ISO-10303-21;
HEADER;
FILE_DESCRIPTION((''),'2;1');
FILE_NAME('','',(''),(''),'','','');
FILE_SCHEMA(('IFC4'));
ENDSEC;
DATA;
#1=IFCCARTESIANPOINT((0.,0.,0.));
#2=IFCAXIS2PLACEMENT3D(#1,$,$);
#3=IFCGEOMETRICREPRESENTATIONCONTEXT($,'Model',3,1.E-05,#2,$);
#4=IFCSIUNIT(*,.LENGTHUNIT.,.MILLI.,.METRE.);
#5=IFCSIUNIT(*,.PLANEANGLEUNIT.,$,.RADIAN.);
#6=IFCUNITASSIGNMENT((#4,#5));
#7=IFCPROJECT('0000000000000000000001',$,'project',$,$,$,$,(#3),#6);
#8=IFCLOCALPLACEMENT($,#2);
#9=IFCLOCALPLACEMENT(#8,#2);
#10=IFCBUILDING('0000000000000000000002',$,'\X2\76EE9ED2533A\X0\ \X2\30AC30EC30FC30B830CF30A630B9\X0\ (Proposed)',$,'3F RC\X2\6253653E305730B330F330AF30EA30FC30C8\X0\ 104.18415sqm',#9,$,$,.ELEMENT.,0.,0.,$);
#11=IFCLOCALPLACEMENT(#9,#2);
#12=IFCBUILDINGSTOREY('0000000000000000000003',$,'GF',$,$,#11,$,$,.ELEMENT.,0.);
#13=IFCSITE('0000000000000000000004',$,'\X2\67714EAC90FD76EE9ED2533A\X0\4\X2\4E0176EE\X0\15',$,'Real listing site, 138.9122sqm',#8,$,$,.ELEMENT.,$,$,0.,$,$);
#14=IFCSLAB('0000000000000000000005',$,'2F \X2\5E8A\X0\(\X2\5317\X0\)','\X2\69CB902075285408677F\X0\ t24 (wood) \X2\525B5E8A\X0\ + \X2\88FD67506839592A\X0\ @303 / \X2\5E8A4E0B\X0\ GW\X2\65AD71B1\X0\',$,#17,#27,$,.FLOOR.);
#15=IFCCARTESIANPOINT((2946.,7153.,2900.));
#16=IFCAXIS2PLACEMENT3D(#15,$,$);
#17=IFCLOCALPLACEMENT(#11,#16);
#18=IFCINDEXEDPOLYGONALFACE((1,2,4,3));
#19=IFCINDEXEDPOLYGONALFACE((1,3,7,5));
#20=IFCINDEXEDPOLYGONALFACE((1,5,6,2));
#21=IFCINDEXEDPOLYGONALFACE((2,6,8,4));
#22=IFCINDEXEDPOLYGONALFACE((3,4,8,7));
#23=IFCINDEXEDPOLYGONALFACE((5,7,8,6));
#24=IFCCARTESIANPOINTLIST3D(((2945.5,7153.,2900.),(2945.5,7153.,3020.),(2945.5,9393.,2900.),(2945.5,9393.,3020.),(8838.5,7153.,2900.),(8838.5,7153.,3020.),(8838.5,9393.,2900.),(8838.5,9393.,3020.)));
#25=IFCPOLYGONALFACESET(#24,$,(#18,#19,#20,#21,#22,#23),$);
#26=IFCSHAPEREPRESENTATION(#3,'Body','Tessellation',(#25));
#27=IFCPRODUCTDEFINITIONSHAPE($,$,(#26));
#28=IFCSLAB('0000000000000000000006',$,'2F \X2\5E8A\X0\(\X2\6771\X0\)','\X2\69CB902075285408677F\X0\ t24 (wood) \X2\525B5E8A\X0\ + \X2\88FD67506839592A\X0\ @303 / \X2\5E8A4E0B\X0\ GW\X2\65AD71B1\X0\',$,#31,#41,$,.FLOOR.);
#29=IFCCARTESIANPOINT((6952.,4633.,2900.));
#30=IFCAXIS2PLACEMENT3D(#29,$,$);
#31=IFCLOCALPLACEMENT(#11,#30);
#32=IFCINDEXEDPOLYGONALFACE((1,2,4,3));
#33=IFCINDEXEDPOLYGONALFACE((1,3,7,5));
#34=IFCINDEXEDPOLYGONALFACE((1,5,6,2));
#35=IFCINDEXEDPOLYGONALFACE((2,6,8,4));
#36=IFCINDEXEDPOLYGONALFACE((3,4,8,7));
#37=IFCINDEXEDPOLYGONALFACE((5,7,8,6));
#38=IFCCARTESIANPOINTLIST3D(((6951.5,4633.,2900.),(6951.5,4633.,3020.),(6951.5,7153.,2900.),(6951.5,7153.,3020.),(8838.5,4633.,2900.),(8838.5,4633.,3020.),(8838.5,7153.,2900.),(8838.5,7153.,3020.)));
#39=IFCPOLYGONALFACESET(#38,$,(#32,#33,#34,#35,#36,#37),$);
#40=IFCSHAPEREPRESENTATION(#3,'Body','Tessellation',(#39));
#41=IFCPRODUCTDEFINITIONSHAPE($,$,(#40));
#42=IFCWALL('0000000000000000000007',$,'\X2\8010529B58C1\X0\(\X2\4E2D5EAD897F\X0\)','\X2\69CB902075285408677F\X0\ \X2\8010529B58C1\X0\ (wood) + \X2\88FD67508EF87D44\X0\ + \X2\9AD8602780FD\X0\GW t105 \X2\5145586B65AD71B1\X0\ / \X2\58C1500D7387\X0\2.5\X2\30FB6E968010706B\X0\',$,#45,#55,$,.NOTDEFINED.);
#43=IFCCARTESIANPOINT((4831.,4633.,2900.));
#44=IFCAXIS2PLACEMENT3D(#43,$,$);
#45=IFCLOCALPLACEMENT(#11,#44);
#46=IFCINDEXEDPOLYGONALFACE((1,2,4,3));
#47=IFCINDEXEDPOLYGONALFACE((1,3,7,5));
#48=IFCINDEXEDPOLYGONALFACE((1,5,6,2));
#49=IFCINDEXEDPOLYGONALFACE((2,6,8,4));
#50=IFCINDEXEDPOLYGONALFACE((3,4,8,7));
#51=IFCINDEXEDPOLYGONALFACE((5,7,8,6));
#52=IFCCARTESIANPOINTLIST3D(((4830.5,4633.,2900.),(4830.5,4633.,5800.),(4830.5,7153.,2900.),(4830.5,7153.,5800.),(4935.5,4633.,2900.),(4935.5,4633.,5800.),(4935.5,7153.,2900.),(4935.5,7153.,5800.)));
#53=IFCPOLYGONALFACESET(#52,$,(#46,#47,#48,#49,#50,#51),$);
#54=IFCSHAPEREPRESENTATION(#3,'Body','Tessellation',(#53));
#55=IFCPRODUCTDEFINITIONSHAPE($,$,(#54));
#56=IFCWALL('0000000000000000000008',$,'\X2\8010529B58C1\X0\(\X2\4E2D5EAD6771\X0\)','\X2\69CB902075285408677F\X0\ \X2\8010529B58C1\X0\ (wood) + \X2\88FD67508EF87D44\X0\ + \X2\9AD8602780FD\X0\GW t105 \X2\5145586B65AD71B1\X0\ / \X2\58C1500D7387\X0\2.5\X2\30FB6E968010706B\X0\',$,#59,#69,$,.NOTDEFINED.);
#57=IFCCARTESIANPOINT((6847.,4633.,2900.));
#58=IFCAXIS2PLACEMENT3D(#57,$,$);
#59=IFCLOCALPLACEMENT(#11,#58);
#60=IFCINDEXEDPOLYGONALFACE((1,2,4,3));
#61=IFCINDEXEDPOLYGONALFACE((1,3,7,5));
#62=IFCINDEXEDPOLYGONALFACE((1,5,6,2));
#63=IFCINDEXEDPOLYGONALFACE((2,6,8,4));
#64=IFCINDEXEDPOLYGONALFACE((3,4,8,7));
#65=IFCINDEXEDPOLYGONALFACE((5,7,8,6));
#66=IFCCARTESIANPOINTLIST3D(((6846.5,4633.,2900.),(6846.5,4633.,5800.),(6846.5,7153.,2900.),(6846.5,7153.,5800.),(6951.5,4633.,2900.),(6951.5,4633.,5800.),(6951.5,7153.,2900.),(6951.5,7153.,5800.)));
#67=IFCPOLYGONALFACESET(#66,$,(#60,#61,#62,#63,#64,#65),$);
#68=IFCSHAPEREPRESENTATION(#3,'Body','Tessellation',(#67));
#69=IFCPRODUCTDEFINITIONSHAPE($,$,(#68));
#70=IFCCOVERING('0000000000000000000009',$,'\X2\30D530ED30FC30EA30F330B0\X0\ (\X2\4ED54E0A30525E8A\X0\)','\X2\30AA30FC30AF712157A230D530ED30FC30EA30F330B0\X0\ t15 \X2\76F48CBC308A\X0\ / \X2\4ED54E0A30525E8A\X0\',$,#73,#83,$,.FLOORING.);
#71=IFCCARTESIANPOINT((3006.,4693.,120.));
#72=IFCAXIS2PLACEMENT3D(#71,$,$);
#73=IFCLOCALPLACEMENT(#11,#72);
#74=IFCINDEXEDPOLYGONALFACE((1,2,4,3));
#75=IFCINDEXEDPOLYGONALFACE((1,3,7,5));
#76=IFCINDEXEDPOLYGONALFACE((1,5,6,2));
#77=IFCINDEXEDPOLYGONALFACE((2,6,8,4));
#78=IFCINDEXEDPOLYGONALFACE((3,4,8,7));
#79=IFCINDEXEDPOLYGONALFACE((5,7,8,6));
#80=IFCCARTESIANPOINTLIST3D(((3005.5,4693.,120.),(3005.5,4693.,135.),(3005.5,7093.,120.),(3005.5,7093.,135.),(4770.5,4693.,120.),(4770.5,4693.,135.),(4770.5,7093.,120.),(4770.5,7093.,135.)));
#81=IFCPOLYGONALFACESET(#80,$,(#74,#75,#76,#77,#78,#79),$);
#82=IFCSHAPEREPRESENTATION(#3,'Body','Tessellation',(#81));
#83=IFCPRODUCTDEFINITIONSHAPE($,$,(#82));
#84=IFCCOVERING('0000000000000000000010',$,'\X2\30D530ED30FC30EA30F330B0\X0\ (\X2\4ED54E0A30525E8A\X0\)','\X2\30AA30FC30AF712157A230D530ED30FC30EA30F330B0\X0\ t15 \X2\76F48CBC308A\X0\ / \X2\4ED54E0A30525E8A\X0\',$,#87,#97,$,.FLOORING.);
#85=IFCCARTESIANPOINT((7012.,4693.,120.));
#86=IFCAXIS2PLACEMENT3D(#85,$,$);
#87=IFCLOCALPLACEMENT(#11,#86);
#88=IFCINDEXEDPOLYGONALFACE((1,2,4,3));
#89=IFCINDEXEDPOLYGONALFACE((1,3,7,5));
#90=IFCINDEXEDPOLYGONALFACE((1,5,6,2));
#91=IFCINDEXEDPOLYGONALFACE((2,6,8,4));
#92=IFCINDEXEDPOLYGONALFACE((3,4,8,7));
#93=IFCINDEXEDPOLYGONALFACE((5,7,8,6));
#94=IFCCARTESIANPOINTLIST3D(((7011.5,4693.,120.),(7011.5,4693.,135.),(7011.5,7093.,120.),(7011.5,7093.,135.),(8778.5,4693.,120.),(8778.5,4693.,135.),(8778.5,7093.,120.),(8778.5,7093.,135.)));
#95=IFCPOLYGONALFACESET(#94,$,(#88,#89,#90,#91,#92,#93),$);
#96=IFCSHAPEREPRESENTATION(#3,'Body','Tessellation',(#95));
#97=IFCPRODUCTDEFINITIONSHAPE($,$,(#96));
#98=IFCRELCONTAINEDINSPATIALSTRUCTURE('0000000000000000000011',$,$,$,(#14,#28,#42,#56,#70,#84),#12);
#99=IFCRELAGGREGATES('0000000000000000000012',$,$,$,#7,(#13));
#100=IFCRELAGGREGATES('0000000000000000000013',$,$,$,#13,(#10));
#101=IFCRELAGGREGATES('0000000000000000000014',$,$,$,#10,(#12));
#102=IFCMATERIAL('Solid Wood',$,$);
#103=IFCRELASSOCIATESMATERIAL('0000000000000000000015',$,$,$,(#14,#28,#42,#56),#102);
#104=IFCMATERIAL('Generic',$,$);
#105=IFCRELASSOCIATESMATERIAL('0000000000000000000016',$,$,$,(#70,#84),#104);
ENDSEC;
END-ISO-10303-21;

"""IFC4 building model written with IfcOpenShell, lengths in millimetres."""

from ifc_helpers import new_model, si_unit, frame, frame_2d, origin, place, context, project, spatial, rectangle, extrude, material, element, save


model = new_model("IFC4")

# Units and contexts
model_context = context("Model", 3, precision=1e-05, world=origin())
ifc_project = project(units=[si_unit("LENGTHUNIT", "METRE", prefix="MILLI"), si_unit("PLANEANGLEUNIT", "RADIAN")], contexts=[model_context])

# Site, building, storey
site_placement = place(None, origin())
site = spatial("IfcSite", under=ifc_project, at=site_placement, Name="東京都目黒区4丁目15", ObjectType="Real listing site, 138.9122sqm", CompositionType="ELEMENT", RefElevation=0.0)
building_placement = place(site_placement, origin())
building = spatial("IfcBuilding", under=site, at=building_placement, Name="目黒区 ガレージハウス (Proposed)", ObjectType="3F RC打放しコンクリート 104.18415sqm", CompositionType="ELEMENT", ElevationOfRefHeight=0.0, ElevationOfTerrain=0.0)
storey_placement = place(building_placement, origin())
storey = spatial("IfcBuildingStorey", under=building, at=storey_placement, Name="GF", CompositionType="ELEMENT", Elevation=0.0)

# Slabs
ifc_material_1 = material(Name="Solid Wood")
slab_1_placement = place(storey_placement, frame((2946.0, 7153.0, 2900.0)))
element("IfcSlab", 1, at=slab_1_placement, inside=storey, material=ifc_material_1, Name="2F 床(北)", Description="構造用合板 t24 (wood) 剛床 + 製材根太 @303 / 床下 GW断熱", PredefinedType="FLOOR", context=model_context, shape_type="SweptSolid", body=[
    extrude(rectangle(XDim=5893.0, YDim=2240.0, at=frame_2d((2946.0, 1120.0))), frame((2946.0, 7153.0, 2900.0)), (0.0, 0.0, 1.0), 120.0),
])
slab_2_placement = place(storey_placement, frame((6952.0, 4633.0, 2900.0)))
element("IfcSlab", 2, at=slab_2_placement, inside=storey, material=ifc_material_1, Name="2F 床(東)", Description="構造用合板 t24 (wood) 剛床 + 製材根太 @303 / 床下 GW断熱", PredefinedType="FLOOR", context=model_context, shape_type="SweptSolid", body=[
    extrude(rectangle(XDim=1887.0, YDim=2520.0, at=frame_2d((943.0, 1260.0))), frame((6952.0, 4633.0, 2900.0)), (0.0, 0.0, 1.0), 120.0),
])

# Walls
wall_1_placement = place(storey_placement, frame((4831.0, 4633.0, 2900.0)))
element("IfcWall", 3, at=wall_1_placement, inside=storey, material=ifc_material_1, Name="耐力壁(中庭西)", Description="構造用合板 耐力壁 (wood) + 製材軸組 + 高性能GW t105 充填断熱 / 壁倍率2.5・準耐火", PredefinedType="NOTDEFINED", context=model_context, shape_type="SweptSolid", body=[
    extrude(rectangle(XDim=105.0, YDim=2520.0, at=frame_2d((52.0, 1260.0))), frame((4831.0, 4633.0, 2900.0)), (0.0, 0.0, 1.0), 2900.0),
])
wall_2_placement = place(storey_placement, frame((6847.0, 4633.0, 2900.0)))
element("IfcWall", 4, at=wall_2_placement, inside=storey, material=ifc_material_1, Name="耐力壁(中庭東)", Description="構造用合板 耐力壁 (wood) + 製材軸組 + 高性能GW t105 充填断熱 / 壁倍率2.5・準耐火", PredefinedType="NOTDEFINED", context=model_context, shape_type="SweptSolid", body=[
    extrude(rectangle(XDim=105.0, YDim=2520.0, at=frame_2d((52.0, 1260.0))), frame((6847.0, 4633.0, 2900.0)), (0.0, 0.0, 1.0), 2900.0),
])

# Coverings
ifc_material_2 = material(Name="Generic")
covering_1_placement = place(storey_placement, frame((3006.0, 4693.0, 120.0)))
element("IfcCovering", 5, at=covering_1_placement, inside=storey, material=ifc_material_2, Name="フローリング (仕上げ床)", Description="オーク無垢フローリング t15 直貼り / 仕上げ床", PredefinedType="FLOORING", context=model_context, shape_type="SweptSolid", body=[
    extrude(rectangle(XDim=1765.0, YDim=2400.0, at=frame_2d((882.0, 1200.0))), frame((3006.0, 4693.0, 120.0)), (0.0, 0.0, 1.0), 15.0),
])
covering_2_placement = place(storey_placement, frame((7012.0, 4693.0, 120.0)))
element("IfcCovering", 6, at=covering_2_placement, inside=storey, material=ifc_material_2, Name="フローリング (仕上げ床)", Description="オーク無垢フローリング t15 直貼り / 仕上げ床", PredefinedType="FLOORING", context=model_context, shape_type="SweptSolid", body=[
    extrude(rectangle(XDim=1767.0, YDim=2400.0, at=frame_2d((883.0, 1200.0))), frame((7012.0, 4693.0, 120.0)), (0.0, 0.0, 1.0), 15.0),
])

save(model, "model.ifc")
